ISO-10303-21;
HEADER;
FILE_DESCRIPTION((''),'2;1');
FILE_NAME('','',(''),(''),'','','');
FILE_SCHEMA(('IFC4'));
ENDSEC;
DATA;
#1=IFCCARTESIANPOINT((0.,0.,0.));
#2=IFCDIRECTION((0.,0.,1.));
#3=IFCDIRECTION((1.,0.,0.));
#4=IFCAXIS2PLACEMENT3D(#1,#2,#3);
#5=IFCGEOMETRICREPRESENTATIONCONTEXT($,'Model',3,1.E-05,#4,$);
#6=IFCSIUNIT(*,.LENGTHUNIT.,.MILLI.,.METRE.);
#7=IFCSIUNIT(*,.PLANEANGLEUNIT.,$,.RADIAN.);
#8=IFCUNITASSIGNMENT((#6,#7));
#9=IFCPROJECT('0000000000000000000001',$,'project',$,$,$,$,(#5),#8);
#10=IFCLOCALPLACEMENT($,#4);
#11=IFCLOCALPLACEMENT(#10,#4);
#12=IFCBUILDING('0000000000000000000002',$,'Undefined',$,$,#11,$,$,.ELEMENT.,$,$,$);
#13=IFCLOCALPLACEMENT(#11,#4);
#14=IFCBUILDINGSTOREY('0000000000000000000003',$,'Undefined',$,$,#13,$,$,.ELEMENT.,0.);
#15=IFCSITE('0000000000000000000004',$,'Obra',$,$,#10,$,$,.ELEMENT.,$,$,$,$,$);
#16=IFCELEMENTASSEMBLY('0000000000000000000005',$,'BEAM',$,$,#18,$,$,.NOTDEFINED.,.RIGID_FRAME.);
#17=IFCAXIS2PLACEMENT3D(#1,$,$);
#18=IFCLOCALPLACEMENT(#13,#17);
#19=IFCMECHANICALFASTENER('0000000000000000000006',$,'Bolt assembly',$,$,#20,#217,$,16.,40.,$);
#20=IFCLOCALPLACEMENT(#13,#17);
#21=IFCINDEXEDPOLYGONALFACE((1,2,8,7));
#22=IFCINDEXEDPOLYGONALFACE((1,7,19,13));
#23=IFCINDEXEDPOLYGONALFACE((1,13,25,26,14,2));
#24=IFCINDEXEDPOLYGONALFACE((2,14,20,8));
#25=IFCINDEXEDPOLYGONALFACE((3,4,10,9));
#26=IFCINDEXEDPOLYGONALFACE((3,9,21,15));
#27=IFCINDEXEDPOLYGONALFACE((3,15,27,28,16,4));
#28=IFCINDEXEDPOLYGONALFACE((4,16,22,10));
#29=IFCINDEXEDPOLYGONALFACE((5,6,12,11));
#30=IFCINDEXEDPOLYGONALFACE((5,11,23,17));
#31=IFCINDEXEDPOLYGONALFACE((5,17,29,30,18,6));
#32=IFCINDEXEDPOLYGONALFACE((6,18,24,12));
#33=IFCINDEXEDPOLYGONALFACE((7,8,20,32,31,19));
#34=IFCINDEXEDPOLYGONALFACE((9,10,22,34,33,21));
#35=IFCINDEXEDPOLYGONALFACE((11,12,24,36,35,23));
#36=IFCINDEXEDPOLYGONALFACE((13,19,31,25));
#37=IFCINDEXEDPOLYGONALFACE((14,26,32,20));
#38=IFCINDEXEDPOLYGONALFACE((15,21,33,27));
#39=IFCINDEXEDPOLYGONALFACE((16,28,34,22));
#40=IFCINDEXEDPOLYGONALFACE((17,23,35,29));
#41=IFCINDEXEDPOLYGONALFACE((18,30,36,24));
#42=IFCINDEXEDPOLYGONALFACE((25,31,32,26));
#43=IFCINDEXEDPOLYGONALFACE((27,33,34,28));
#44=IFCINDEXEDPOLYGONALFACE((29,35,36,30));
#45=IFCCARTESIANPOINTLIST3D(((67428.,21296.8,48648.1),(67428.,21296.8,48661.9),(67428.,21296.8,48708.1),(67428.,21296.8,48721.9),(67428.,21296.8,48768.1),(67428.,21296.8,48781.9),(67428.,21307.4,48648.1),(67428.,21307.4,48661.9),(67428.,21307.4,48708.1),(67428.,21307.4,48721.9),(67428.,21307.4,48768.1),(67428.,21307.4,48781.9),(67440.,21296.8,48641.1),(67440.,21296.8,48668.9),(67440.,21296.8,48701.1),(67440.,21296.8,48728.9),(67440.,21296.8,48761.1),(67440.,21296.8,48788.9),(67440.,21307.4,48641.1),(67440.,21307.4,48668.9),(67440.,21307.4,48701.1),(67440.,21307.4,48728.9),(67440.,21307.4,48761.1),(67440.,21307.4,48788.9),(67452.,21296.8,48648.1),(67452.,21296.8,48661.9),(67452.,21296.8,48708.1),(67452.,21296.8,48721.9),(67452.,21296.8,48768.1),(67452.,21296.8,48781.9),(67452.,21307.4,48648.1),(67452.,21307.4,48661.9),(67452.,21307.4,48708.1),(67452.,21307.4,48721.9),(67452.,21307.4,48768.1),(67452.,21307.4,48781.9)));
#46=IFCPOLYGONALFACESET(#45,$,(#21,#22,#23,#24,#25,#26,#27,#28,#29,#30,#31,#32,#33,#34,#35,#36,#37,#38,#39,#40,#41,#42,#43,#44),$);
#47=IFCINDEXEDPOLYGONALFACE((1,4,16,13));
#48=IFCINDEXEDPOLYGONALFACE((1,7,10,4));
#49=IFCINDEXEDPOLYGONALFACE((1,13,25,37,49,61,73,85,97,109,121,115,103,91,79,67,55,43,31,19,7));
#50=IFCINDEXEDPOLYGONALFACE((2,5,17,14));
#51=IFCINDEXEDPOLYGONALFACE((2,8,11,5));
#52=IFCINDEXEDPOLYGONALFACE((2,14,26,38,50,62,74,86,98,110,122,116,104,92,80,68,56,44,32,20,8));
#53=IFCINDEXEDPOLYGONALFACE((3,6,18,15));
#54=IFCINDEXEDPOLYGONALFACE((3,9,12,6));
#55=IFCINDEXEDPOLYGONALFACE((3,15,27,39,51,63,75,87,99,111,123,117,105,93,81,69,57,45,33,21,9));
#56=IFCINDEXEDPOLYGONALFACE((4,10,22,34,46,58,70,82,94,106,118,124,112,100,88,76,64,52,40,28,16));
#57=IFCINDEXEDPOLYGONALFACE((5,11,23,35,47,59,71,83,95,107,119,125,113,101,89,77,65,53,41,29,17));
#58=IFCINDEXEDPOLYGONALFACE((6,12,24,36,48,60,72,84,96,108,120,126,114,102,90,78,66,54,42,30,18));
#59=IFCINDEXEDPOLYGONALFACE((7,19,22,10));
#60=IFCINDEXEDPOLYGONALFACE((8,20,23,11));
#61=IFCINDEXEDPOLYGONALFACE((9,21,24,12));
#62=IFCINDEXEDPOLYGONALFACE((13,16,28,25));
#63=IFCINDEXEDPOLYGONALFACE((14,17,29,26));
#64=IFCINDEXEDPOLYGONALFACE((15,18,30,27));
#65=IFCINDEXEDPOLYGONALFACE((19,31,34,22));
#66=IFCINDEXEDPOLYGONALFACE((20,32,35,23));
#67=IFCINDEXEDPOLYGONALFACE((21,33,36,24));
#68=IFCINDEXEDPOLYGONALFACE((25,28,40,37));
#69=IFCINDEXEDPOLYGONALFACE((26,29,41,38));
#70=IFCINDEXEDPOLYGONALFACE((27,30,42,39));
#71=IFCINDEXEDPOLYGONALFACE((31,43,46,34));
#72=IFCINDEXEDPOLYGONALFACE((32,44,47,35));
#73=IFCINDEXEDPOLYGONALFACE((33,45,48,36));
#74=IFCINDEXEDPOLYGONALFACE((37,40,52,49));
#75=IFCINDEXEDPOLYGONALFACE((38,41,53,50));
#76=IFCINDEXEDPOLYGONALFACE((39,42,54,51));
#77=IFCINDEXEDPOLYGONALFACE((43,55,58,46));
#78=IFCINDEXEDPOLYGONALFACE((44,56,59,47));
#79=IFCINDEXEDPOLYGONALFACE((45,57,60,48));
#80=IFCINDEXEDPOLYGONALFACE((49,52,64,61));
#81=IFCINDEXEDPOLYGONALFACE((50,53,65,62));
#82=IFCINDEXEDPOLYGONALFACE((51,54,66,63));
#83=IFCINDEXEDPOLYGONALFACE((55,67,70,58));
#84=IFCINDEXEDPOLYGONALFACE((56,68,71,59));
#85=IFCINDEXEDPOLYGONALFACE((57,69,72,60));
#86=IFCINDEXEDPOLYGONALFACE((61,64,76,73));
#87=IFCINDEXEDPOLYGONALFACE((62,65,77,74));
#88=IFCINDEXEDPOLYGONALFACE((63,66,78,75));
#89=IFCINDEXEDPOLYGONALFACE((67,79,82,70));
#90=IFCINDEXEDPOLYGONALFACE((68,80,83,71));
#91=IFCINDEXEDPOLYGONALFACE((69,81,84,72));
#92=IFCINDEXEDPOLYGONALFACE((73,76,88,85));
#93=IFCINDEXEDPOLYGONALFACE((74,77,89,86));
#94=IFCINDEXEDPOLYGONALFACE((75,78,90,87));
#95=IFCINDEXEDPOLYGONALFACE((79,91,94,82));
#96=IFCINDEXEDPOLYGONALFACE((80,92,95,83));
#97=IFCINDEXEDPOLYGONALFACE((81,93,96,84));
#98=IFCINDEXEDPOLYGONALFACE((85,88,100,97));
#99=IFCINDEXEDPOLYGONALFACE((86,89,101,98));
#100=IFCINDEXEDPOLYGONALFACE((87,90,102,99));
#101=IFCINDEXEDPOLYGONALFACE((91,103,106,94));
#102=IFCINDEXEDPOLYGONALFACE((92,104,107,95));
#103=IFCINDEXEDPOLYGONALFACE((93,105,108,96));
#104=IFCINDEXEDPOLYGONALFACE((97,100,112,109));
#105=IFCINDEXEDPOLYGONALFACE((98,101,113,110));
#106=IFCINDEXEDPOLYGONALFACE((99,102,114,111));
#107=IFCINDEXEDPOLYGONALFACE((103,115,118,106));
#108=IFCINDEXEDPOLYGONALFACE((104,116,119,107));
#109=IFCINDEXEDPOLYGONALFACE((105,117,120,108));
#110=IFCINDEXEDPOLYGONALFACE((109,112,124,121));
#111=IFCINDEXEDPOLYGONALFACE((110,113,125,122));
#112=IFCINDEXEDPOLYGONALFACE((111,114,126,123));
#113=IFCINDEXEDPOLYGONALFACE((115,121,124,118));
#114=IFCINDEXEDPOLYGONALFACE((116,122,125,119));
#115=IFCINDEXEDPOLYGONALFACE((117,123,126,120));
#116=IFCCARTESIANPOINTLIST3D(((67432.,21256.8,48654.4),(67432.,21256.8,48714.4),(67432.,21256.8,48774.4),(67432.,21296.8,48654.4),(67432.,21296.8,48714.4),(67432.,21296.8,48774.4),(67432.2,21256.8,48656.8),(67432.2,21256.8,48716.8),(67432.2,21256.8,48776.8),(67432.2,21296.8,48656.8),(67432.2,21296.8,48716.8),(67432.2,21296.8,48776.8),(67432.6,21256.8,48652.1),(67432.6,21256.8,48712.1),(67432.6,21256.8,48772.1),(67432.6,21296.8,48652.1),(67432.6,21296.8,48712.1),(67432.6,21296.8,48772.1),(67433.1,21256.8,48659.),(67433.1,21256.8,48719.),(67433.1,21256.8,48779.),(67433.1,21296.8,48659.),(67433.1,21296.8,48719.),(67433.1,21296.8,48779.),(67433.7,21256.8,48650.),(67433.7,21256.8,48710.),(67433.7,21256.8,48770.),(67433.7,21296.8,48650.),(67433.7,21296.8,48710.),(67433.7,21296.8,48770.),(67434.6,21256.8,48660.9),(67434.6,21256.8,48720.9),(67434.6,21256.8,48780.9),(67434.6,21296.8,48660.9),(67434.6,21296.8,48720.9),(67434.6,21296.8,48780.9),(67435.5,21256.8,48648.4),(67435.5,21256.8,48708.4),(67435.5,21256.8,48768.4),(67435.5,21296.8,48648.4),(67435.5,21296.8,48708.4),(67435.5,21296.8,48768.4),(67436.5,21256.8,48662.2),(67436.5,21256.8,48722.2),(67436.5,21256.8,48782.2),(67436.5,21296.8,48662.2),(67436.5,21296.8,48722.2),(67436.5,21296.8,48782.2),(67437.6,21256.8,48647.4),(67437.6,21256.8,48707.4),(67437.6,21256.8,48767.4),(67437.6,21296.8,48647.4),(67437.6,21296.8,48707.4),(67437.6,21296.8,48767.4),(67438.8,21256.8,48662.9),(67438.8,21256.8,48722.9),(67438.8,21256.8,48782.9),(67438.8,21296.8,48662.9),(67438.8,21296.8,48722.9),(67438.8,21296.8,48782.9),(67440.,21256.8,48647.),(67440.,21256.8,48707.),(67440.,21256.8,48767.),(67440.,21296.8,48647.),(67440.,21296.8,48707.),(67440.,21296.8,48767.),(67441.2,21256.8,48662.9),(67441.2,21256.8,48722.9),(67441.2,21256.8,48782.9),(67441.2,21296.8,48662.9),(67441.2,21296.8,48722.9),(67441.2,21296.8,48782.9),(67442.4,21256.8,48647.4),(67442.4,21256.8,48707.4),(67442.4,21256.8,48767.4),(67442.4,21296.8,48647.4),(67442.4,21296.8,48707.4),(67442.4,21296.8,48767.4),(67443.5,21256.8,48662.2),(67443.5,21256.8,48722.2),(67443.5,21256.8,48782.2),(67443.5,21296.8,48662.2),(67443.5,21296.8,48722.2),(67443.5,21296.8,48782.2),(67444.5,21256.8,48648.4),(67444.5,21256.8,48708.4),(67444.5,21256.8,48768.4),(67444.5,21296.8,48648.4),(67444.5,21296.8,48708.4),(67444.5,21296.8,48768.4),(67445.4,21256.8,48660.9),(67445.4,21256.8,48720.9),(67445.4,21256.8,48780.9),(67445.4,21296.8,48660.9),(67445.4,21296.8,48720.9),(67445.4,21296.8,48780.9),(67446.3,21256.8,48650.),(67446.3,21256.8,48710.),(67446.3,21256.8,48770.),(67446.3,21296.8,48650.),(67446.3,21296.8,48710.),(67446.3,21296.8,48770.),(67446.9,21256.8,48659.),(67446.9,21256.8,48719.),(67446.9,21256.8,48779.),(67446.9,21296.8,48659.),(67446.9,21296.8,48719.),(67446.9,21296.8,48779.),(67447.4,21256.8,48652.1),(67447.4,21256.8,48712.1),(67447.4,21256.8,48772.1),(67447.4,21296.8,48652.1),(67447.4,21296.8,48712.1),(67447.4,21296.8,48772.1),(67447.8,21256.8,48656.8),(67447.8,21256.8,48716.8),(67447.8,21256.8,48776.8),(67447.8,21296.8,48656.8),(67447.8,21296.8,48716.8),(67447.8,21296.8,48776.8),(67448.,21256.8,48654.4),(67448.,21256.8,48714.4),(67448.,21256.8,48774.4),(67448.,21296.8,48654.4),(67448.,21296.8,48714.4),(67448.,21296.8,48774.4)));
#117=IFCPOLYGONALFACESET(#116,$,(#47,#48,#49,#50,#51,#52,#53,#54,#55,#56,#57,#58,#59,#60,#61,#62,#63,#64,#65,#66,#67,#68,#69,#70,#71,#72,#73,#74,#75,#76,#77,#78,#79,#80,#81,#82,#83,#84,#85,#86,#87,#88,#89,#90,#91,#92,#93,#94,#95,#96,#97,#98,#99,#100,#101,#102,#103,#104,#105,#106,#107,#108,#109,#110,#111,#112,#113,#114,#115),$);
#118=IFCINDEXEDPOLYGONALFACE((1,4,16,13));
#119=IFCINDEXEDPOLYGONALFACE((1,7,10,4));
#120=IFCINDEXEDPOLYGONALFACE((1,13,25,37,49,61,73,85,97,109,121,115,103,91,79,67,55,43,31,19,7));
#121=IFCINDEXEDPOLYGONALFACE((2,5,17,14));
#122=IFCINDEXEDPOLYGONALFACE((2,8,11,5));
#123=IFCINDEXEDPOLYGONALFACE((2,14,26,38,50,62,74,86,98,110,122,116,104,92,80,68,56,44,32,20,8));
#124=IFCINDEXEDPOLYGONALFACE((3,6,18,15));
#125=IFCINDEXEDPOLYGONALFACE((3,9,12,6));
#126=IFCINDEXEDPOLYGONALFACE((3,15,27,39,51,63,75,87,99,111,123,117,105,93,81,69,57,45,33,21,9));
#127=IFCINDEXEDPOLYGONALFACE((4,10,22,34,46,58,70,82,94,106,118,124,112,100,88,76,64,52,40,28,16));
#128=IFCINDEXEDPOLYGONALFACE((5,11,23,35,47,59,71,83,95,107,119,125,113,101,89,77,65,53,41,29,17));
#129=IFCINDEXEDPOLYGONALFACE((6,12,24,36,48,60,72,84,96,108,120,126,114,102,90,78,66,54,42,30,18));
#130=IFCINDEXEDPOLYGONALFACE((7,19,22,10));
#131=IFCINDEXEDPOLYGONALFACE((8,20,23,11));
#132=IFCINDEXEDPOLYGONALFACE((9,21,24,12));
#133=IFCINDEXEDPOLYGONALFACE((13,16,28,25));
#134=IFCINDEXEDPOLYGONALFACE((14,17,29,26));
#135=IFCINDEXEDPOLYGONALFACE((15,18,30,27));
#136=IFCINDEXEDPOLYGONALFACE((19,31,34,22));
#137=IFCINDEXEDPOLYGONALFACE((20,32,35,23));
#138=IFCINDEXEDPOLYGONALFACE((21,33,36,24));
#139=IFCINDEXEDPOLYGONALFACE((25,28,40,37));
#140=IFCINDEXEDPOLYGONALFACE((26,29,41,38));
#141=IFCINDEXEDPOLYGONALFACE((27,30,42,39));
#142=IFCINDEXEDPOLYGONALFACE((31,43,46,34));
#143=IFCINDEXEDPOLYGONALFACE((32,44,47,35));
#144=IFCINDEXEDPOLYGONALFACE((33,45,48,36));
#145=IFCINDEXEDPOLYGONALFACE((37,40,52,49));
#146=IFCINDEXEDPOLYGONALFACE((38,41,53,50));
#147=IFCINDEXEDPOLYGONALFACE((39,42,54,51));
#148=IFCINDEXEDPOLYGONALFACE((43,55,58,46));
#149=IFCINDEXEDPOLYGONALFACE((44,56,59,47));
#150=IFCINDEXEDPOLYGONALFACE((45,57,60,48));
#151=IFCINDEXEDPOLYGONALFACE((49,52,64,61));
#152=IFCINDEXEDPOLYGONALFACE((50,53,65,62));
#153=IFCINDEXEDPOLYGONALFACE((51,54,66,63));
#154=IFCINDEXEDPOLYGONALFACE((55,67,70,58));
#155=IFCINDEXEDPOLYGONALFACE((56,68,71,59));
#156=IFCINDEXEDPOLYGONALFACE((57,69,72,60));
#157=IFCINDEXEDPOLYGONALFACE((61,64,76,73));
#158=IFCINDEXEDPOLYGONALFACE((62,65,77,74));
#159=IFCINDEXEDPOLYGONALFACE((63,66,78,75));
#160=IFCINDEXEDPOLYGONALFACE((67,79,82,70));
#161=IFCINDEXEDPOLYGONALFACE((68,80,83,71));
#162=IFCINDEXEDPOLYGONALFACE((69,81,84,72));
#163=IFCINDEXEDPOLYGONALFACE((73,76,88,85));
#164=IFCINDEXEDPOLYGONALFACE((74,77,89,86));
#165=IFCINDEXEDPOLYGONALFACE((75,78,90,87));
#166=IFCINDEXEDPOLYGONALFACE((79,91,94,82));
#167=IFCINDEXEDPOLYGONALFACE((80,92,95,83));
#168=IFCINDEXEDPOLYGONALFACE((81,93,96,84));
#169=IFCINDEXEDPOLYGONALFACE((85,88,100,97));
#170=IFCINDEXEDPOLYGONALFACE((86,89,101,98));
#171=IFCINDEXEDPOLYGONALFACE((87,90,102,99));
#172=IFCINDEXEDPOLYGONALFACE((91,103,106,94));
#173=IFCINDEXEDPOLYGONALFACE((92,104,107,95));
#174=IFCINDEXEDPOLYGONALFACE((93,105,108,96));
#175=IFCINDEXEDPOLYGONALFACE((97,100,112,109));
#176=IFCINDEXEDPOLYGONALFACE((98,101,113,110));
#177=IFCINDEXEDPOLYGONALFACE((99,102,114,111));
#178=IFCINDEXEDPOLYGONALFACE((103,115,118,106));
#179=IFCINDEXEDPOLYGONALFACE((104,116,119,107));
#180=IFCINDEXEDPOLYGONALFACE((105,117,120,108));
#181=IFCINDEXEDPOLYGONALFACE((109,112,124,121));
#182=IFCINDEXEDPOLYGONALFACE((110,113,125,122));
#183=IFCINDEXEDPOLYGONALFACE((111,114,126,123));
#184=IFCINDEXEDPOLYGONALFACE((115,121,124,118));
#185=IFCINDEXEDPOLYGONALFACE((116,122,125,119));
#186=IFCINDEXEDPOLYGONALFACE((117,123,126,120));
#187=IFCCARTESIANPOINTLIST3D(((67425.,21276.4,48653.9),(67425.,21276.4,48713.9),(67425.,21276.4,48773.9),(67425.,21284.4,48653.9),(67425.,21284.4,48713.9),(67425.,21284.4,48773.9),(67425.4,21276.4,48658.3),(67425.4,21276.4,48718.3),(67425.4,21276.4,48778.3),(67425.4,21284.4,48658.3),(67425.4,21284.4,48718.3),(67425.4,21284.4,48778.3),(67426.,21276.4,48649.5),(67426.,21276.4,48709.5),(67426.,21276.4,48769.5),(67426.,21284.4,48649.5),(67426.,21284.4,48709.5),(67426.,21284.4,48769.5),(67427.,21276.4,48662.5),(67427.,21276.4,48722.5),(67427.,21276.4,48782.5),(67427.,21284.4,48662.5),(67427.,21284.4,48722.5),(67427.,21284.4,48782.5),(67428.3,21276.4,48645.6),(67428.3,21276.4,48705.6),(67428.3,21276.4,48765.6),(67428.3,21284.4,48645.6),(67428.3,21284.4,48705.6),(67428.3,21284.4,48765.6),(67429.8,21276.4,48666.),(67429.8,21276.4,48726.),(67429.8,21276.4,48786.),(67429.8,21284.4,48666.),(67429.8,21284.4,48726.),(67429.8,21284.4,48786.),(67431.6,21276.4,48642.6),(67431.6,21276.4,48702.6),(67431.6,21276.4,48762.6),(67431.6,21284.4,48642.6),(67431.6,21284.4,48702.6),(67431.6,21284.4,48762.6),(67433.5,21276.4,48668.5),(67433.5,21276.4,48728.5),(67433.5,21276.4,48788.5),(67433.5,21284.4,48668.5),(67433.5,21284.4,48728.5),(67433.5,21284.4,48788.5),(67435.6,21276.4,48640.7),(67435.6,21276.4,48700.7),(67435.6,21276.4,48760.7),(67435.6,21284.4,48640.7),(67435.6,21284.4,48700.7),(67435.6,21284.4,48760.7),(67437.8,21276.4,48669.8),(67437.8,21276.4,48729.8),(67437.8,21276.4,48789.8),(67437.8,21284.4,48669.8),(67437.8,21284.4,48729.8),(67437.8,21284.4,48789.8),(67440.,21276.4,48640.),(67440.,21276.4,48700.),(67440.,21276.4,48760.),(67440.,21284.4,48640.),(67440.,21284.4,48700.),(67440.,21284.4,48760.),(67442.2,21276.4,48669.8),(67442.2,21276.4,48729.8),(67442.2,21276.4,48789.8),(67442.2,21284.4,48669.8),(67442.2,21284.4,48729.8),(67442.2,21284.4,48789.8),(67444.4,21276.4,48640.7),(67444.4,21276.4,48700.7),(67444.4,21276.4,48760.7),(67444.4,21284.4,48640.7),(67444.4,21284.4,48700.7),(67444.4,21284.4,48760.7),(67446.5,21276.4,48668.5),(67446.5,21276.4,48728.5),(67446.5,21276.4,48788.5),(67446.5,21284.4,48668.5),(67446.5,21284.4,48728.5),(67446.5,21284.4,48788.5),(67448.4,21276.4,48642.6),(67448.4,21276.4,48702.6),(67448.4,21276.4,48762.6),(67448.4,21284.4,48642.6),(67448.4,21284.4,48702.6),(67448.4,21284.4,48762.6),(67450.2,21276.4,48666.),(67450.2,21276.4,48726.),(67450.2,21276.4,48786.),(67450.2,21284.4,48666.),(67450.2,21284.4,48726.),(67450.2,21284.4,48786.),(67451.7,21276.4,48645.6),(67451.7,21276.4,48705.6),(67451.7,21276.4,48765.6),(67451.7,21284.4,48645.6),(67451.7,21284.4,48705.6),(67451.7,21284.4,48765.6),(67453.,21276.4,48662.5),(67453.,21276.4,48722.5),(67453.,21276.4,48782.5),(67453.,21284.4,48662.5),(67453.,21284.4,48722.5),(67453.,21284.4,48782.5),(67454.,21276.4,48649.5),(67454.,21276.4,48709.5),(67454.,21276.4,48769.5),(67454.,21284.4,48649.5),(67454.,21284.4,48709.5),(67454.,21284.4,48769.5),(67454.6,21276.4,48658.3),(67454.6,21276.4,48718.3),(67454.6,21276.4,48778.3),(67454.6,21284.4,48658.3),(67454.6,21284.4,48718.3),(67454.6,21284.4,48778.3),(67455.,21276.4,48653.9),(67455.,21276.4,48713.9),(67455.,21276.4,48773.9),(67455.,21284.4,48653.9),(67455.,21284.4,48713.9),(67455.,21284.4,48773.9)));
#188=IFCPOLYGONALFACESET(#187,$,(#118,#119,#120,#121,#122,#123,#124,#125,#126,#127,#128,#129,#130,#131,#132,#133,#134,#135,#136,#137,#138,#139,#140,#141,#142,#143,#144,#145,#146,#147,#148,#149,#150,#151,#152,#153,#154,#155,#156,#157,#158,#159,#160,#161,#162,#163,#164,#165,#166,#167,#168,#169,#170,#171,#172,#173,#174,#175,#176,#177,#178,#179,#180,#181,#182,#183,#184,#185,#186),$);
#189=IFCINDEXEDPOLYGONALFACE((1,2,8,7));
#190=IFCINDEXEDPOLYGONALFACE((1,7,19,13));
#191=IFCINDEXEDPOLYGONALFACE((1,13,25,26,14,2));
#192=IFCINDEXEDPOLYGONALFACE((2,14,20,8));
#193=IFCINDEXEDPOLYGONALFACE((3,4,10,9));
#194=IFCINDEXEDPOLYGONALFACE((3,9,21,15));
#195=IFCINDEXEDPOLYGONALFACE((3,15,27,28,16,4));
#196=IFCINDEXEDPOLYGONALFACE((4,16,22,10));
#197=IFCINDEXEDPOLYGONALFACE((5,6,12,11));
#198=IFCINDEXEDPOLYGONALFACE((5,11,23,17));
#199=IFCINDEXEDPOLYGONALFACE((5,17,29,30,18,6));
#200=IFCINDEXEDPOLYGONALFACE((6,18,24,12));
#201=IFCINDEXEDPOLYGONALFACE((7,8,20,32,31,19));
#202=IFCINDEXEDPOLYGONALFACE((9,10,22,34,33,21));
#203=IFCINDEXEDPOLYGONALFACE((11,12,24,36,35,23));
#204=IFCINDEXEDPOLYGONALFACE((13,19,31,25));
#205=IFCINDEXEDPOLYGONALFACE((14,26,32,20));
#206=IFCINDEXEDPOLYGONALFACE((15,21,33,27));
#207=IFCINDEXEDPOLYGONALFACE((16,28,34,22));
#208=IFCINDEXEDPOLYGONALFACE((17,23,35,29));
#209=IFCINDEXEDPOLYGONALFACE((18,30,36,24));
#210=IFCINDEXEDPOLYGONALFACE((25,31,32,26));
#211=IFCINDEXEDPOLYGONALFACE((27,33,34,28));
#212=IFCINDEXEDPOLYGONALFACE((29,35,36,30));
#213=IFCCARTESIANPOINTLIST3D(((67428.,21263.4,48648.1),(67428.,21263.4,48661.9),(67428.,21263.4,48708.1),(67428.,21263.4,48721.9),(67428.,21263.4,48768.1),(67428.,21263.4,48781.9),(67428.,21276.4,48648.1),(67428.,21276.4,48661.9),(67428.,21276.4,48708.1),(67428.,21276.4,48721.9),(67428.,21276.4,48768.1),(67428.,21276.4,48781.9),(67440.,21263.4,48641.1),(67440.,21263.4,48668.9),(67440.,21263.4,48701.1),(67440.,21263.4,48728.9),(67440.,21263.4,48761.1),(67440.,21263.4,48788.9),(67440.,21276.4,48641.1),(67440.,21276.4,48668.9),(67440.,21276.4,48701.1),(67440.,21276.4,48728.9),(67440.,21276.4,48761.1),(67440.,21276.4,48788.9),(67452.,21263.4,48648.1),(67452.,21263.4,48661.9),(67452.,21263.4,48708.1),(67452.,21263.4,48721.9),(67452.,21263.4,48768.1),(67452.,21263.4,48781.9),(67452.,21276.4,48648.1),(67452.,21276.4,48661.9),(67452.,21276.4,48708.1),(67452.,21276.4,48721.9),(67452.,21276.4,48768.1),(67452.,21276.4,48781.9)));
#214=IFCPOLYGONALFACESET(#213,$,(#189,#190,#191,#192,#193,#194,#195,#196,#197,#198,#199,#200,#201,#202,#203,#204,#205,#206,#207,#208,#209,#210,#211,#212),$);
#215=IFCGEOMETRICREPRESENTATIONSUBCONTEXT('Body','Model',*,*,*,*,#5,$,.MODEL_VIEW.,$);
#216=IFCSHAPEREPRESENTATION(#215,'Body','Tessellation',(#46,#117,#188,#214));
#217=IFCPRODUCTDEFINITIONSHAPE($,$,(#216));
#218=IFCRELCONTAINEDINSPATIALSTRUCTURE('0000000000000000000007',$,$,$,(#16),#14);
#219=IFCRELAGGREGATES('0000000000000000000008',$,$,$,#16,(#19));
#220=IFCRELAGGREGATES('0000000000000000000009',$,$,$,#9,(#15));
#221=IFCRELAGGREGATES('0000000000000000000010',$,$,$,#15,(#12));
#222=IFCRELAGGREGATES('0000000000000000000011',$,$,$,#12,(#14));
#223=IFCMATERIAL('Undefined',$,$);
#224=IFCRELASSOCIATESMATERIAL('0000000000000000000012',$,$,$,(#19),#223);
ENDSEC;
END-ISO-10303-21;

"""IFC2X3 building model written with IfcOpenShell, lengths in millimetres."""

from ifc_helpers import new_model, si_unit, frame, origin_with_axes, origin_2d_with_axis, place, context, subcontext, project, spatial, polyline, circle, outline, extrude, source, transform, mapped, material, element, aggregate, save


model = new_model("IFC2X3")

# Units and contexts
model_context = context("Model", 3, precision=1e-05, world=origin_with_axes())
body_context = subcontext(model_context, "Body", "Model", "MODEL_VIEW")
ifc_project = project(units=[si_unit("LENGTHUNIT", "METRE", prefix="MILLI"), si_unit("PLANEANGLEUNIT", "RADIAN")], contexts=[model_context])

# Site, building, storey
site_placement = place(None, origin_with_axes())
site = spatial("IfcSite", under=ifc_project, at=site_placement, Name="Obra", CompositionType="ELEMENT")
building_placement = place(site_placement, origin_with_axes())
building = spatial("IfcBuilding", under=site, at=building_placement, Name="Undefined", CompositionType="ELEMENT")
storey_placement = place(building_placement, origin_with_axes())
storey = spatial("IfcBuildingStorey", under=building, at=storey_placement, Name="Undefined", CompositionType="ELEMENT", Elevation=0.0)

# Element assembly, mechanical fastener
assembly_1_placement = place(storey_placement, origin_with_axes())
assembly_1 = element("IfcElementAssembly", 1, at=assembly_1_placement, inside=storey, Name="BEAM", AssemblyPlace="NOTDEFINED", PredefinedType="RIGID_FRAME")
ifc_material_1 = material(Name="Undefined")
shared_shape_1 = source(origin_with_axes(), body_context, "Body", "SweptSolid", [
    extrude(outline(polyline([(13.9, 0.0), (6.9, 12.0), (-6.9, 12.0), (-13.9, 0.0), (-6.9, -12.0), (6.9, -12.0), (13.9, 0.0)])), frame((0.0, -19.7, 0.0), z_axis=(0.0, 1.0, 0.0), x_axis=(1.0, 0.0, 0.0)), (0.0, 0.0, 1.0), 10.6),
    extrude(circle(Radius=8.0, at=origin_2d_with_axis()), frame((0.0, -9.1, 0.0), z_axis=(0.0, 1.0, 0.0), x_axis=(1.0, 0.0, 0.0)), (0.0, 0.0, 1.0), 40.0),
    extrude(circle(Radius=15.0, at=origin_2d_with_axis()), frame((0.0, 3.3, 0.0), z_axis=(0.0, 1.0, 0.0), x_axis=(1.0, 0.0, 0.0)), (0.0, 0.0, 1.0), 8.0),
    extrude(outline(polyline([(13.9, 0.0), (6.9, 12.0), (-6.9, 12.0), (-13.9, 0.0), (-6.9, -12.0), (6.9, -12.0), (13.9, 0.0)])), frame((0.0, 11.3, 0.0), z_axis=(0.0, 1.0, 0.0), x_axis=(1.0, 0.0, 0.0)), (0.0, 0.0, 1.0), 13.0),
])
mechanical_fastener_1_placement = place(assembly_1_placement, frame((67490.0, 21287.7, 48835.0), z_axis=(-1.0, 0.0, 0.0), x_axis=(0.0, 0.0, -1.0)))
mechanical_fastener_1 = element("IfcMechanicalFastener", 2, at=mechanical_fastener_1_placement, material=ifc_material_1, Name="Bolt assembly", NominalDiameter=16.0, NominalLength=40.0, context=body_context, shape_type="MappedRepresentation", body=[
    mapped(shared_shape_1, transform((60.0, 0.0, 50.0))),
    mapped(shared_shape_1, transform((120.0, 0.0, 50.0))),
    mapped(shared_shape_1, transform((180.0, 0.0, 50.0))),
])
aggregate(assembly_1, [mechanical_fastener_1])

save(model, "model.ifc")
